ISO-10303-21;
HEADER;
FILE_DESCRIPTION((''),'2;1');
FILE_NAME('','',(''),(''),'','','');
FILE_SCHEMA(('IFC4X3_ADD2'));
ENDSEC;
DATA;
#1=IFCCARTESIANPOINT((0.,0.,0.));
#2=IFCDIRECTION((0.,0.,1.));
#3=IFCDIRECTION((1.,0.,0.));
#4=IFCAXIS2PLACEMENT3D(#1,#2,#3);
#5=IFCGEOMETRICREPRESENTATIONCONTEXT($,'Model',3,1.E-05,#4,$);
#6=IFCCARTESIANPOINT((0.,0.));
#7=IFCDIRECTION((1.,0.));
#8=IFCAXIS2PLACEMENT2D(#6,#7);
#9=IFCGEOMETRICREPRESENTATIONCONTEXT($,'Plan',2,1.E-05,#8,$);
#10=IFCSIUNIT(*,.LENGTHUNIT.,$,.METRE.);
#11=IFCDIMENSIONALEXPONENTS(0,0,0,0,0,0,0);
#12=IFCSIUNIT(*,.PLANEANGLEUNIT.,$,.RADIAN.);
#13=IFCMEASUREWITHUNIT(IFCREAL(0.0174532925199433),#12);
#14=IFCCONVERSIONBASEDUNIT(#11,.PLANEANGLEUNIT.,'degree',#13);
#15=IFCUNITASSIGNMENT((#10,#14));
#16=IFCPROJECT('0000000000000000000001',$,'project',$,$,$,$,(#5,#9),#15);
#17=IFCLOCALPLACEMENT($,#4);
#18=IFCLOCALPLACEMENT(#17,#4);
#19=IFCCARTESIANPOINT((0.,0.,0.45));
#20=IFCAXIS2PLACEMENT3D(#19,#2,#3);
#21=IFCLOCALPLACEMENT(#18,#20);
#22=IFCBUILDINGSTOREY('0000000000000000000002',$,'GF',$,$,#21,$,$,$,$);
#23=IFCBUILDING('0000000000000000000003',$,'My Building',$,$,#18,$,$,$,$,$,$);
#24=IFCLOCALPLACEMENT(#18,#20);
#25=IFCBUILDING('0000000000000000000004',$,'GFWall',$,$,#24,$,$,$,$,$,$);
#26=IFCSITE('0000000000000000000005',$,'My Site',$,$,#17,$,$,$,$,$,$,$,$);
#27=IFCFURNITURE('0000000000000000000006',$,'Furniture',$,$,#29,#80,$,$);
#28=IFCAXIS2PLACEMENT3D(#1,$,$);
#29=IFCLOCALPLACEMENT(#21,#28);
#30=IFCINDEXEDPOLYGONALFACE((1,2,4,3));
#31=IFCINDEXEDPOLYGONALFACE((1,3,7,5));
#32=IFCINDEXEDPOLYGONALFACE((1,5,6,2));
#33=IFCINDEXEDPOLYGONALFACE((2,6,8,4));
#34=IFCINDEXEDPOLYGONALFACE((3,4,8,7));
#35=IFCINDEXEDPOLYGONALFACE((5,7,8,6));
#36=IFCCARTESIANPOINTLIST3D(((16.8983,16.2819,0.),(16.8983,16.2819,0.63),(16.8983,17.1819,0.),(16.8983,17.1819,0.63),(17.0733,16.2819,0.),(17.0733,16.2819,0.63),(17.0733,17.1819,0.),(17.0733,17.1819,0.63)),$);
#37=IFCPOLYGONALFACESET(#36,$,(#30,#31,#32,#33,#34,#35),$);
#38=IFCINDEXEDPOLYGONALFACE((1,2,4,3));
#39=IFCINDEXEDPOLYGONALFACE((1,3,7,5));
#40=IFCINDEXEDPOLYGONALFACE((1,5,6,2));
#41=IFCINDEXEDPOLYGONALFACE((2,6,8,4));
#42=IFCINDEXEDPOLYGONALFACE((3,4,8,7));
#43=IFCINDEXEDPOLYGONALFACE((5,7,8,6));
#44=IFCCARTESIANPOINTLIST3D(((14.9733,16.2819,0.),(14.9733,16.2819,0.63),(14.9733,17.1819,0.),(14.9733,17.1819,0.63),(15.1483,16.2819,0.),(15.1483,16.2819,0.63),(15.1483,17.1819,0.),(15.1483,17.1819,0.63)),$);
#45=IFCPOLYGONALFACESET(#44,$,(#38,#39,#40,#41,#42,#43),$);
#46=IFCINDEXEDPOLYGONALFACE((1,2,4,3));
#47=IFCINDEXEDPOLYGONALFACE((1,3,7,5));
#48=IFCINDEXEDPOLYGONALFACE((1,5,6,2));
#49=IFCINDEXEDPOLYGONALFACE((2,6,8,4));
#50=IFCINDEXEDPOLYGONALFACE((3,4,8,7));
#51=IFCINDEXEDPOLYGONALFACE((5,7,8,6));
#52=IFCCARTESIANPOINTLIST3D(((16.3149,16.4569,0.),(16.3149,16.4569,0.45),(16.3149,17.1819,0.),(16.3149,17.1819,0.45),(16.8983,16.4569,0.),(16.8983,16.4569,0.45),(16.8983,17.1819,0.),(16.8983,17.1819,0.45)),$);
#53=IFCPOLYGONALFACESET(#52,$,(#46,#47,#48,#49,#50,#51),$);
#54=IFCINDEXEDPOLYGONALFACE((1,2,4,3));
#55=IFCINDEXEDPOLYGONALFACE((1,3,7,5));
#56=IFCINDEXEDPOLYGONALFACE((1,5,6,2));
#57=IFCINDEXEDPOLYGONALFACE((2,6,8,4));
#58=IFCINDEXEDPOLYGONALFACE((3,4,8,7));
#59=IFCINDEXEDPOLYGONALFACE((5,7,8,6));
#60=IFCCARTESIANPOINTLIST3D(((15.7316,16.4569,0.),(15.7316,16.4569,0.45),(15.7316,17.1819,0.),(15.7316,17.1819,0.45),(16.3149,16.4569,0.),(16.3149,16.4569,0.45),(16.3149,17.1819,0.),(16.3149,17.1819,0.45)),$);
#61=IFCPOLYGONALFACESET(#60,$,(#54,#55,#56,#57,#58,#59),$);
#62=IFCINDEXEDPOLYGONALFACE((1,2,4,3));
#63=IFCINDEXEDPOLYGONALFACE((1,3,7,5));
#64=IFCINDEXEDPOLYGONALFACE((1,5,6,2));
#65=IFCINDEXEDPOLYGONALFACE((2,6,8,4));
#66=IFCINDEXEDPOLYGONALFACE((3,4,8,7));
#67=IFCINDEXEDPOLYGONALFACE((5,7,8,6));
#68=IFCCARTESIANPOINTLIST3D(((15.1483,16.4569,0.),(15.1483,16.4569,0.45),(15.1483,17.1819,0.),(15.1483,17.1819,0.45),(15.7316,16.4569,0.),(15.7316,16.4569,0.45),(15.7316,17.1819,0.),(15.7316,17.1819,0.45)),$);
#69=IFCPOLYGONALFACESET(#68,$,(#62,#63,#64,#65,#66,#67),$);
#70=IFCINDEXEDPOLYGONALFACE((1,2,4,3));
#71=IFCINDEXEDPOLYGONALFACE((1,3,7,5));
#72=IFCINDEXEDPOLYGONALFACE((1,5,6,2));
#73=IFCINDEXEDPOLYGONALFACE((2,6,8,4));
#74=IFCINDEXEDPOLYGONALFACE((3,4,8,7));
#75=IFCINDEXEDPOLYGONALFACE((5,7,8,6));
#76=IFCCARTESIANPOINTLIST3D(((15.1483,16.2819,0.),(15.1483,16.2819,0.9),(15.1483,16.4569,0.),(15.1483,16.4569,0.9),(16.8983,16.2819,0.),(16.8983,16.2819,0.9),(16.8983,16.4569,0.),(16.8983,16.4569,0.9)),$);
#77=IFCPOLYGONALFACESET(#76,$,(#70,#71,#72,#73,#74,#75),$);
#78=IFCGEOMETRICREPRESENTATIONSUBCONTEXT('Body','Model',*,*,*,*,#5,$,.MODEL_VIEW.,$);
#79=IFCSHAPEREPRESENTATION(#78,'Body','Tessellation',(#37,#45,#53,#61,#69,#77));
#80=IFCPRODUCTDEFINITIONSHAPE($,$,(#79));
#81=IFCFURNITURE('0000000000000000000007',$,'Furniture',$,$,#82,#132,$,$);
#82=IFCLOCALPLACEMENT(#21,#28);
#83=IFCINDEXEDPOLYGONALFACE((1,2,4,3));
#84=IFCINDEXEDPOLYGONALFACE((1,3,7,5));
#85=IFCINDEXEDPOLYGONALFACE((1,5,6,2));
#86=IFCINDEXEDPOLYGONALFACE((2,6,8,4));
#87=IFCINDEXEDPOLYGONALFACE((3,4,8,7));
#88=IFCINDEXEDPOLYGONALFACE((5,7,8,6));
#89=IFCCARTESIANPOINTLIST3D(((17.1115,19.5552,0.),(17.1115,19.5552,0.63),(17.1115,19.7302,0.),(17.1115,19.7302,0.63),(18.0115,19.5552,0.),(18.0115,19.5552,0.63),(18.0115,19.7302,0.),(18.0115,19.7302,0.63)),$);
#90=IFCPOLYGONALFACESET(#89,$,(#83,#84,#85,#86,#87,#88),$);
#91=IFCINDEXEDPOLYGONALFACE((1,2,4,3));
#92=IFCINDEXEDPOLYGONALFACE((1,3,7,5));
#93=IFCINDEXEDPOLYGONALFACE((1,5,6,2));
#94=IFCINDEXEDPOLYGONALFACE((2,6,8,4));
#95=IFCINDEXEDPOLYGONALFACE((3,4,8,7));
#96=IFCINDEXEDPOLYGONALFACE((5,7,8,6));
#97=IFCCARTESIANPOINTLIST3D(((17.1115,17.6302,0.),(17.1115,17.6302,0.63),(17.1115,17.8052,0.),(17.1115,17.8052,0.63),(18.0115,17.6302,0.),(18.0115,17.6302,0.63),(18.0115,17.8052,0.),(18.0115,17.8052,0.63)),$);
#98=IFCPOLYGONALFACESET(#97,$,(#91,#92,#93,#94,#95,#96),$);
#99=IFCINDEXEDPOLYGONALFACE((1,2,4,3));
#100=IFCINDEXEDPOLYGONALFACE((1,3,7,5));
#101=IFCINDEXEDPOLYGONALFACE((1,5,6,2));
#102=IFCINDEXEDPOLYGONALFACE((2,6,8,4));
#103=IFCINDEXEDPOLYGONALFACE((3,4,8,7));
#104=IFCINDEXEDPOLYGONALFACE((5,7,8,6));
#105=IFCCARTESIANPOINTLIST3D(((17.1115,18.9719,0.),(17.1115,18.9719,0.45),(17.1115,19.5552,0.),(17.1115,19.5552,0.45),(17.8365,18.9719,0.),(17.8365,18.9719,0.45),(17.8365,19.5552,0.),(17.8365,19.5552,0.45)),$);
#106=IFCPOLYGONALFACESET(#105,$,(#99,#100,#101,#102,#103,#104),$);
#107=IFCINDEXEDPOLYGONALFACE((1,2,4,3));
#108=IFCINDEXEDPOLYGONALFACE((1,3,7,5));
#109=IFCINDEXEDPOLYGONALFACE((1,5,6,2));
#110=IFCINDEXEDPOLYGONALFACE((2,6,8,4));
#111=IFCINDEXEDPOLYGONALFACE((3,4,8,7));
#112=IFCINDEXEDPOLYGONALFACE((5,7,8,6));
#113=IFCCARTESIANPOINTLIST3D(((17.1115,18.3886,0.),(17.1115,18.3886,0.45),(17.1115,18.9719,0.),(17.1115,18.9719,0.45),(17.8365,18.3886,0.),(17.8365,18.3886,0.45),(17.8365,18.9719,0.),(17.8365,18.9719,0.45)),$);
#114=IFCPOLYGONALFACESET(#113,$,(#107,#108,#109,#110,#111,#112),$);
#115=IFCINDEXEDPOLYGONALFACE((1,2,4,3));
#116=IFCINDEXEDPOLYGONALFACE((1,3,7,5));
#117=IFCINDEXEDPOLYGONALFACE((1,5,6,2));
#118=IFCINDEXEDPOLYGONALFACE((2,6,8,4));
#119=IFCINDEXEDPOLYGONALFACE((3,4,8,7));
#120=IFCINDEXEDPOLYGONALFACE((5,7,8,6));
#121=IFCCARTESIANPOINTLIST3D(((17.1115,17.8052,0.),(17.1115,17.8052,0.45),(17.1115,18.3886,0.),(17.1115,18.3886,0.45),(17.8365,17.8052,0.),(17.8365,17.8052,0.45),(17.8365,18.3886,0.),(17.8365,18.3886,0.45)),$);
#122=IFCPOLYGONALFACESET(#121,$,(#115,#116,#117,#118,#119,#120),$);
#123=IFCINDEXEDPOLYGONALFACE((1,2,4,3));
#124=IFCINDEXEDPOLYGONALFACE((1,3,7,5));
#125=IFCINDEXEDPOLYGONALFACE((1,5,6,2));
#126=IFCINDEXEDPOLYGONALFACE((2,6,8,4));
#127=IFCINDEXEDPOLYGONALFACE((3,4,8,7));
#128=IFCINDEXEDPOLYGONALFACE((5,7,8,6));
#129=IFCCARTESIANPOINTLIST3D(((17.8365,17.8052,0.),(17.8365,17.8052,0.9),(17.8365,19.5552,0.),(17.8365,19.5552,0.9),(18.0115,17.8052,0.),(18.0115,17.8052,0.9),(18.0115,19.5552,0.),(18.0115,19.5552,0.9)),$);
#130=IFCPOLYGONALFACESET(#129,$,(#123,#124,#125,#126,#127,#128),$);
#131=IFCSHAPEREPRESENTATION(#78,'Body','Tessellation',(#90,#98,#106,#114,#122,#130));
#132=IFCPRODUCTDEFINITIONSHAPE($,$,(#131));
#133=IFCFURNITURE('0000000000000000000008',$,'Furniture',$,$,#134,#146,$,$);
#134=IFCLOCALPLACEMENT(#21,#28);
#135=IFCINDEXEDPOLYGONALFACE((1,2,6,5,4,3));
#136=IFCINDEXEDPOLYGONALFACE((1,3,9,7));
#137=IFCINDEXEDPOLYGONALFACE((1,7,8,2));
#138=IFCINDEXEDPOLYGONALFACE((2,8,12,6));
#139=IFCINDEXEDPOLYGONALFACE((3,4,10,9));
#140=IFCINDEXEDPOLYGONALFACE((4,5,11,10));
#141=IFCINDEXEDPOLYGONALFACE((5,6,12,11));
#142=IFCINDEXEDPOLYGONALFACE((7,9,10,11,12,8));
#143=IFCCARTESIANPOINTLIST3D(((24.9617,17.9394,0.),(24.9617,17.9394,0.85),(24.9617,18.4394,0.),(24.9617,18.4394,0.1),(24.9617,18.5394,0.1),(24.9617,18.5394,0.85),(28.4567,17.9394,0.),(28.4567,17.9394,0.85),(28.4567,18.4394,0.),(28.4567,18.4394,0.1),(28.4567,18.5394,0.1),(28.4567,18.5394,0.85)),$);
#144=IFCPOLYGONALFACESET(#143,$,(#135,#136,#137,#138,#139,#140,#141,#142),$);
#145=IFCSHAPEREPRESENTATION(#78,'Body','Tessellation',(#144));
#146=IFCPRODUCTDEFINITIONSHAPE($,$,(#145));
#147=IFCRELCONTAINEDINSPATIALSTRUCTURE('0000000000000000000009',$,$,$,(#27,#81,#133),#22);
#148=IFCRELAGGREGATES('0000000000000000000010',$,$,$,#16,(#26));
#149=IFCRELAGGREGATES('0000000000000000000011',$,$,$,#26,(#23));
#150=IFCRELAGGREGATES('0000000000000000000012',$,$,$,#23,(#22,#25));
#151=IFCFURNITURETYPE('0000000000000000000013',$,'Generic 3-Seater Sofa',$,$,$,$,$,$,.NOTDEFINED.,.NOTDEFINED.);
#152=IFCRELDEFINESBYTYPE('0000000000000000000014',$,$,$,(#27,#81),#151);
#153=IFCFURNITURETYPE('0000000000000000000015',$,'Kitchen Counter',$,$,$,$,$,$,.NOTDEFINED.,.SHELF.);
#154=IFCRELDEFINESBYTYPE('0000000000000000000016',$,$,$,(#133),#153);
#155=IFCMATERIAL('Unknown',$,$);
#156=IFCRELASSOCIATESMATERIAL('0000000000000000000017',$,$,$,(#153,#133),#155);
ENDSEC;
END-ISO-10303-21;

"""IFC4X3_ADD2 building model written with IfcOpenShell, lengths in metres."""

from ifc_helpers import new_model, entity, si_unit, converted_unit, frame, origin_with_axes, origin_2d_with_axis, place, context, subcontext, project, spatial, line, indexed_curve, outline, extrude, shape, source, transform, mapped, material, material_profile, profile_set, profile_usage, type_object, type_shapes, element, save


model = new_model("IFC4X3_ADD2")

# Units and contexts
model_context = context("Model", 3, precision=1e-05, world=origin_with_axes())
plan_context = context("Plan", 2, precision=1e-05, world=origin_2d_with_axis())
body_context_1 = subcontext(model_context, "Body", "Model", "MODEL_VIEW")
body_context_2 = subcontext(plan_context, "Body", "Plan", "PLAN_VIEW")
ifc_project = project(units=[si_unit("LENGTHUNIT", "METRE"), converted_unit("PLANEANGLEUNIT", "degree", entity("IfcReal", 0.0174532925199433), si_unit("PLANEANGLEUNIT", "RADIAN"), dimensions=[0, 0, 0, 0, 0, 0, 0])], contexts=[model_context, plan_context])

# Site, building, storey
site_placement = place(None, origin_with_axes())
site = spatial("IfcSite", under=ifc_project, at=site_placement, Name="My Site")
building_1_placement = place(site_placement, origin_with_axes())
building_1 = spatial("IfcBuilding", under=site, at=building_1_placement, Name="My Building")
storey_placement = place(building_1_placement, frame((0.0, 0.0, 0.45), z_axis=(0.0, 0.0, 1.0), x_axis=(1.0, 0.0, 0.0)))
storey = spatial("IfcBuildingStorey", under=building_1, at=storey_placement, Name="GF")

# Shared definitions
building_2_placement = place(building_1_placement, frame((0.0, 0.0, 0.45), z_axis=(0.0, 0.0, 1.0), x_axis=(1.0, 0.0, 0.0)))
building_2 = spatial("IfcBuilding", under=building_1, at=building_2_placement, Name="GFWall")

# Furniture
furniture_type_1 = type_object("IfcFurnitureType", Name="Generic 3-Seater Sofa", AssemblyPlace="NOTDEFINED", PredefinedType="NOTDEFINED")
shared_shape_1 = source(origin_with_axes(), body_context_1, "Body", "SweptSolid", [
    extrude(outline(indexed_curve([(0.0, 0.0), (0.175, 0.0), (0.175, 0.9), (0.0, 0.9)], segments=[line(1, 2, 3, 4, 1)])), frame((-1.05, -0.9, 0.0), z_axis=(0.0, 0.0, 1.0), x_axis=(1.0, 0.0, 0.0)), (0.0, 0.0, 1.0), 0.63),
    extrude(outline(indexed_curve([(0.0, 0.0), (0.175, 0.0), (0.175, 0.9), (0.0, 0.9)], segments=[line(1, 2, 3, 4, 1)])), frame((0.875, -0.9, 0.0), z_axis=(0.0, 0.0, 1.0), x_axis=(1.0, 0.0, 0.0)), (0.0, 0.0, 1.0), 0.63),
    extrude(outline(indexed_curve([(0.175, 0.0), (0.7583, 0.0), (0.7583, 0.725), (0.175, 0.725)], segments=[line(1, 2, 3, 4, 1)])), frame((-1.05, -0.9, 0.0), z_axis=(0.0, 0.0, 1.0), x_axis=(1.0, 0.0, 0.0)), (0.0, 0.0, 1.0), 0.45),
    extrude(outline(indexed_curve([(0.7583, 0.0), (1.3417, 0.0), (1.3417, 0.725), (0.7583, 0.725)], segments=[line(1, 2, 3, 4, 1)])), frame((-1.05, -0.9, 0.0), z_axis=(0.0, 0.0, 1.0), x_axis=(1.0, 0.0, 0.0)), (0.0, 0.0, 1.0), 0.45),
    extrude(outline(indexed_curve([(1.3417, 0.0), (1.925, 0.0), (1.925, 0.725), (1.3417, 0.725)], segments=[line(1, 2, 3, 4, 1)])), frame((-1.05, -0.9, 0.0), z_axis=(0.0, 0.0, 1.0), x_axis=(1.0, 0.0, 0.0)), (0.0, 0.0, 1.0), 0.45),
    extrude(outline(indexed_curve([(0.175, 0.725), (1.925, 0.725), (1.925, 0.9), (0.175, 0.9)], segments=[line(1, 2, 3, 4, 1)])), frame((-1.05, -0.9, 0.0), z_axis=(0.0, 0.0, 1.0), x_axis=(1.0, 0.0, 0.0)), (0.0, 0.0, 1.0), 0.9),
])
shared_shape_2 = source(origin_with_axes(), body_context_2, "Body", "Curve2D", [
    entity("IfcIndexedPolyCurve", entity("IfcCartesianPointList2D", [[-1.05, -0.9], [-0.875, -0.9], [-0.875, 0.0], [-1.05, 0.0]]), [entity("IfcLineIndex", [1, 2, 3, 4, 1])]),
    entity("IfcIndexedPolyCurve", entity("IfcCartesianPointList2D", [[0.875, -0.9], [1.05, -0.9], [1.05, 0.0], [0.875, 0.0]]), [entity("IfcLineIndex", [1, 2, 3, 4, 1])]),
    entity("IfcIndexedPolyCurve", entity("IfcCartesianPointList2D", [[-0.875, -0.9], [-0.2917, -0.9], [-0.2917, -0.175], [-0.875, -0.175]]), [entity("IfcLineIndex", [1, 2, 3, 4, 1])]),
    entity("IfcIndexedPolyCurve", entity("IfcCartesianPointList2D", [[-0.2917, -0.9], [0.2917, -0.9], [0.2917, -0.175], [-0.2917, -0.175]]), [entity("IfcLineIndex", [1, 2, 3, 4, 1])]),
    entity("IfcIndexedPolyCurve", entity("IfcCartesianPointList2D", [[0.2917, -0.9], [0.875, -0.9], [0.875, -0.175], [0.2917, -0.175]]), [entity("IfcLineIndex", [1, 2, 3, 4, 1])]),
    entity("IfcIndexedPolyCurve", entity("IfcCartesianPointList2D", [[-0.875, -0.175], [0.875, -0.175], [0.875, 0.0], [-0.875, 0.0]]), [entity("IfcLineIndex", [1, 2, 3, 4, 1])]),
])
type_shapes(furniture_type_1, [shared_shape_1, shared_shape_2])
for number, where, z_axis, x_axis, name in (
    (1, (16.0233, 16.2819, 0.0), (0.0, 0.0, 1.0), (-1.0, 0.0, 0.0), "Furniture"),
    (2, (18.0115, 18.6802, 0.0), (0.0, 0.0, 1.0), (0.0, -1.0, 0.0), "Furniture"),
):
    element("IfcFurniture", number, at=place(storey_placement, frame(where, z_axis=z_axis, x_axis=x_axis)), inside=storey, type_object=furniture_type_1, Name=name, shapes=[
        shape(body_context_1, "Body", "MappedRepresentation", [mapped(shared_shape_1, transform((0.0, 0.0, 0.0), x_axis=(1.0, 0.0, 0.0), y_axis=(0.0, 1.0, 0.0), z_axis=(0.0, 0.0, 1.0), scale=1.0))]),
        shape(body_context_2, "Body", "MappedRepresentation", [mapped(shared_shape_2, transform((0.0, 0.0, 0.0), x_axis=(1.0, 0.0, 0.0), y_axis=(0.0, 1.0, 0.0), z_axis=(0.0, 0.0, 1.0), scale=1.0))]),
    ])
ifc_material_1 = material(Name="Unknown")
ifc_material_profile_1 = material_profile(ifc_material_1, outline(indexed_curve([(0.5, 0.1), (0.6, 0.1), (0.6, 0.85), (0.0, 0.85), (0.0, 0.0), (0.5, 0.0), (0.5, 0.1)])))
ifc_profile_set_1 = profile_set([ifc_material_profile_1])
ifc_profile_usage_1 = profile_usage(ifc_profile_set_1, cardinal=5)
furniture_type_2 = type_object("IfcFurnitureType", Name="Kitchen Counter", AssemblyPlace="NOTDEFINED", PredefinedType="SHELF", material=ifc_profile_set_1)
furniture_1_placement = place(storey_placement, frame((24.9617, 17.9394, 0.0), z_axis=(1.0, 0.0, 0.0), x_axis=(0.0, 1.0, 0.0)))
element("IfcFurniture", 3, at=furniture_1_placement, inside=storey, type_object=furniture_type_2, material=ifc_profile_usage_1, Name="Furniture", context=body_context_1, shape_type="SweptSolid", body=[
    extrude(outline(indexed_curve([(0.5, 0.1), (0.6, 0.1), (0.6, 0.85), (0.0, 0.85), (0.0, 0.0), (0.5, 0.0), (0.5, 0.1)])), origin_with_axes(), (0.0, 0.0, 1.0), 3.495),
])

save(model, "model.ifc")
